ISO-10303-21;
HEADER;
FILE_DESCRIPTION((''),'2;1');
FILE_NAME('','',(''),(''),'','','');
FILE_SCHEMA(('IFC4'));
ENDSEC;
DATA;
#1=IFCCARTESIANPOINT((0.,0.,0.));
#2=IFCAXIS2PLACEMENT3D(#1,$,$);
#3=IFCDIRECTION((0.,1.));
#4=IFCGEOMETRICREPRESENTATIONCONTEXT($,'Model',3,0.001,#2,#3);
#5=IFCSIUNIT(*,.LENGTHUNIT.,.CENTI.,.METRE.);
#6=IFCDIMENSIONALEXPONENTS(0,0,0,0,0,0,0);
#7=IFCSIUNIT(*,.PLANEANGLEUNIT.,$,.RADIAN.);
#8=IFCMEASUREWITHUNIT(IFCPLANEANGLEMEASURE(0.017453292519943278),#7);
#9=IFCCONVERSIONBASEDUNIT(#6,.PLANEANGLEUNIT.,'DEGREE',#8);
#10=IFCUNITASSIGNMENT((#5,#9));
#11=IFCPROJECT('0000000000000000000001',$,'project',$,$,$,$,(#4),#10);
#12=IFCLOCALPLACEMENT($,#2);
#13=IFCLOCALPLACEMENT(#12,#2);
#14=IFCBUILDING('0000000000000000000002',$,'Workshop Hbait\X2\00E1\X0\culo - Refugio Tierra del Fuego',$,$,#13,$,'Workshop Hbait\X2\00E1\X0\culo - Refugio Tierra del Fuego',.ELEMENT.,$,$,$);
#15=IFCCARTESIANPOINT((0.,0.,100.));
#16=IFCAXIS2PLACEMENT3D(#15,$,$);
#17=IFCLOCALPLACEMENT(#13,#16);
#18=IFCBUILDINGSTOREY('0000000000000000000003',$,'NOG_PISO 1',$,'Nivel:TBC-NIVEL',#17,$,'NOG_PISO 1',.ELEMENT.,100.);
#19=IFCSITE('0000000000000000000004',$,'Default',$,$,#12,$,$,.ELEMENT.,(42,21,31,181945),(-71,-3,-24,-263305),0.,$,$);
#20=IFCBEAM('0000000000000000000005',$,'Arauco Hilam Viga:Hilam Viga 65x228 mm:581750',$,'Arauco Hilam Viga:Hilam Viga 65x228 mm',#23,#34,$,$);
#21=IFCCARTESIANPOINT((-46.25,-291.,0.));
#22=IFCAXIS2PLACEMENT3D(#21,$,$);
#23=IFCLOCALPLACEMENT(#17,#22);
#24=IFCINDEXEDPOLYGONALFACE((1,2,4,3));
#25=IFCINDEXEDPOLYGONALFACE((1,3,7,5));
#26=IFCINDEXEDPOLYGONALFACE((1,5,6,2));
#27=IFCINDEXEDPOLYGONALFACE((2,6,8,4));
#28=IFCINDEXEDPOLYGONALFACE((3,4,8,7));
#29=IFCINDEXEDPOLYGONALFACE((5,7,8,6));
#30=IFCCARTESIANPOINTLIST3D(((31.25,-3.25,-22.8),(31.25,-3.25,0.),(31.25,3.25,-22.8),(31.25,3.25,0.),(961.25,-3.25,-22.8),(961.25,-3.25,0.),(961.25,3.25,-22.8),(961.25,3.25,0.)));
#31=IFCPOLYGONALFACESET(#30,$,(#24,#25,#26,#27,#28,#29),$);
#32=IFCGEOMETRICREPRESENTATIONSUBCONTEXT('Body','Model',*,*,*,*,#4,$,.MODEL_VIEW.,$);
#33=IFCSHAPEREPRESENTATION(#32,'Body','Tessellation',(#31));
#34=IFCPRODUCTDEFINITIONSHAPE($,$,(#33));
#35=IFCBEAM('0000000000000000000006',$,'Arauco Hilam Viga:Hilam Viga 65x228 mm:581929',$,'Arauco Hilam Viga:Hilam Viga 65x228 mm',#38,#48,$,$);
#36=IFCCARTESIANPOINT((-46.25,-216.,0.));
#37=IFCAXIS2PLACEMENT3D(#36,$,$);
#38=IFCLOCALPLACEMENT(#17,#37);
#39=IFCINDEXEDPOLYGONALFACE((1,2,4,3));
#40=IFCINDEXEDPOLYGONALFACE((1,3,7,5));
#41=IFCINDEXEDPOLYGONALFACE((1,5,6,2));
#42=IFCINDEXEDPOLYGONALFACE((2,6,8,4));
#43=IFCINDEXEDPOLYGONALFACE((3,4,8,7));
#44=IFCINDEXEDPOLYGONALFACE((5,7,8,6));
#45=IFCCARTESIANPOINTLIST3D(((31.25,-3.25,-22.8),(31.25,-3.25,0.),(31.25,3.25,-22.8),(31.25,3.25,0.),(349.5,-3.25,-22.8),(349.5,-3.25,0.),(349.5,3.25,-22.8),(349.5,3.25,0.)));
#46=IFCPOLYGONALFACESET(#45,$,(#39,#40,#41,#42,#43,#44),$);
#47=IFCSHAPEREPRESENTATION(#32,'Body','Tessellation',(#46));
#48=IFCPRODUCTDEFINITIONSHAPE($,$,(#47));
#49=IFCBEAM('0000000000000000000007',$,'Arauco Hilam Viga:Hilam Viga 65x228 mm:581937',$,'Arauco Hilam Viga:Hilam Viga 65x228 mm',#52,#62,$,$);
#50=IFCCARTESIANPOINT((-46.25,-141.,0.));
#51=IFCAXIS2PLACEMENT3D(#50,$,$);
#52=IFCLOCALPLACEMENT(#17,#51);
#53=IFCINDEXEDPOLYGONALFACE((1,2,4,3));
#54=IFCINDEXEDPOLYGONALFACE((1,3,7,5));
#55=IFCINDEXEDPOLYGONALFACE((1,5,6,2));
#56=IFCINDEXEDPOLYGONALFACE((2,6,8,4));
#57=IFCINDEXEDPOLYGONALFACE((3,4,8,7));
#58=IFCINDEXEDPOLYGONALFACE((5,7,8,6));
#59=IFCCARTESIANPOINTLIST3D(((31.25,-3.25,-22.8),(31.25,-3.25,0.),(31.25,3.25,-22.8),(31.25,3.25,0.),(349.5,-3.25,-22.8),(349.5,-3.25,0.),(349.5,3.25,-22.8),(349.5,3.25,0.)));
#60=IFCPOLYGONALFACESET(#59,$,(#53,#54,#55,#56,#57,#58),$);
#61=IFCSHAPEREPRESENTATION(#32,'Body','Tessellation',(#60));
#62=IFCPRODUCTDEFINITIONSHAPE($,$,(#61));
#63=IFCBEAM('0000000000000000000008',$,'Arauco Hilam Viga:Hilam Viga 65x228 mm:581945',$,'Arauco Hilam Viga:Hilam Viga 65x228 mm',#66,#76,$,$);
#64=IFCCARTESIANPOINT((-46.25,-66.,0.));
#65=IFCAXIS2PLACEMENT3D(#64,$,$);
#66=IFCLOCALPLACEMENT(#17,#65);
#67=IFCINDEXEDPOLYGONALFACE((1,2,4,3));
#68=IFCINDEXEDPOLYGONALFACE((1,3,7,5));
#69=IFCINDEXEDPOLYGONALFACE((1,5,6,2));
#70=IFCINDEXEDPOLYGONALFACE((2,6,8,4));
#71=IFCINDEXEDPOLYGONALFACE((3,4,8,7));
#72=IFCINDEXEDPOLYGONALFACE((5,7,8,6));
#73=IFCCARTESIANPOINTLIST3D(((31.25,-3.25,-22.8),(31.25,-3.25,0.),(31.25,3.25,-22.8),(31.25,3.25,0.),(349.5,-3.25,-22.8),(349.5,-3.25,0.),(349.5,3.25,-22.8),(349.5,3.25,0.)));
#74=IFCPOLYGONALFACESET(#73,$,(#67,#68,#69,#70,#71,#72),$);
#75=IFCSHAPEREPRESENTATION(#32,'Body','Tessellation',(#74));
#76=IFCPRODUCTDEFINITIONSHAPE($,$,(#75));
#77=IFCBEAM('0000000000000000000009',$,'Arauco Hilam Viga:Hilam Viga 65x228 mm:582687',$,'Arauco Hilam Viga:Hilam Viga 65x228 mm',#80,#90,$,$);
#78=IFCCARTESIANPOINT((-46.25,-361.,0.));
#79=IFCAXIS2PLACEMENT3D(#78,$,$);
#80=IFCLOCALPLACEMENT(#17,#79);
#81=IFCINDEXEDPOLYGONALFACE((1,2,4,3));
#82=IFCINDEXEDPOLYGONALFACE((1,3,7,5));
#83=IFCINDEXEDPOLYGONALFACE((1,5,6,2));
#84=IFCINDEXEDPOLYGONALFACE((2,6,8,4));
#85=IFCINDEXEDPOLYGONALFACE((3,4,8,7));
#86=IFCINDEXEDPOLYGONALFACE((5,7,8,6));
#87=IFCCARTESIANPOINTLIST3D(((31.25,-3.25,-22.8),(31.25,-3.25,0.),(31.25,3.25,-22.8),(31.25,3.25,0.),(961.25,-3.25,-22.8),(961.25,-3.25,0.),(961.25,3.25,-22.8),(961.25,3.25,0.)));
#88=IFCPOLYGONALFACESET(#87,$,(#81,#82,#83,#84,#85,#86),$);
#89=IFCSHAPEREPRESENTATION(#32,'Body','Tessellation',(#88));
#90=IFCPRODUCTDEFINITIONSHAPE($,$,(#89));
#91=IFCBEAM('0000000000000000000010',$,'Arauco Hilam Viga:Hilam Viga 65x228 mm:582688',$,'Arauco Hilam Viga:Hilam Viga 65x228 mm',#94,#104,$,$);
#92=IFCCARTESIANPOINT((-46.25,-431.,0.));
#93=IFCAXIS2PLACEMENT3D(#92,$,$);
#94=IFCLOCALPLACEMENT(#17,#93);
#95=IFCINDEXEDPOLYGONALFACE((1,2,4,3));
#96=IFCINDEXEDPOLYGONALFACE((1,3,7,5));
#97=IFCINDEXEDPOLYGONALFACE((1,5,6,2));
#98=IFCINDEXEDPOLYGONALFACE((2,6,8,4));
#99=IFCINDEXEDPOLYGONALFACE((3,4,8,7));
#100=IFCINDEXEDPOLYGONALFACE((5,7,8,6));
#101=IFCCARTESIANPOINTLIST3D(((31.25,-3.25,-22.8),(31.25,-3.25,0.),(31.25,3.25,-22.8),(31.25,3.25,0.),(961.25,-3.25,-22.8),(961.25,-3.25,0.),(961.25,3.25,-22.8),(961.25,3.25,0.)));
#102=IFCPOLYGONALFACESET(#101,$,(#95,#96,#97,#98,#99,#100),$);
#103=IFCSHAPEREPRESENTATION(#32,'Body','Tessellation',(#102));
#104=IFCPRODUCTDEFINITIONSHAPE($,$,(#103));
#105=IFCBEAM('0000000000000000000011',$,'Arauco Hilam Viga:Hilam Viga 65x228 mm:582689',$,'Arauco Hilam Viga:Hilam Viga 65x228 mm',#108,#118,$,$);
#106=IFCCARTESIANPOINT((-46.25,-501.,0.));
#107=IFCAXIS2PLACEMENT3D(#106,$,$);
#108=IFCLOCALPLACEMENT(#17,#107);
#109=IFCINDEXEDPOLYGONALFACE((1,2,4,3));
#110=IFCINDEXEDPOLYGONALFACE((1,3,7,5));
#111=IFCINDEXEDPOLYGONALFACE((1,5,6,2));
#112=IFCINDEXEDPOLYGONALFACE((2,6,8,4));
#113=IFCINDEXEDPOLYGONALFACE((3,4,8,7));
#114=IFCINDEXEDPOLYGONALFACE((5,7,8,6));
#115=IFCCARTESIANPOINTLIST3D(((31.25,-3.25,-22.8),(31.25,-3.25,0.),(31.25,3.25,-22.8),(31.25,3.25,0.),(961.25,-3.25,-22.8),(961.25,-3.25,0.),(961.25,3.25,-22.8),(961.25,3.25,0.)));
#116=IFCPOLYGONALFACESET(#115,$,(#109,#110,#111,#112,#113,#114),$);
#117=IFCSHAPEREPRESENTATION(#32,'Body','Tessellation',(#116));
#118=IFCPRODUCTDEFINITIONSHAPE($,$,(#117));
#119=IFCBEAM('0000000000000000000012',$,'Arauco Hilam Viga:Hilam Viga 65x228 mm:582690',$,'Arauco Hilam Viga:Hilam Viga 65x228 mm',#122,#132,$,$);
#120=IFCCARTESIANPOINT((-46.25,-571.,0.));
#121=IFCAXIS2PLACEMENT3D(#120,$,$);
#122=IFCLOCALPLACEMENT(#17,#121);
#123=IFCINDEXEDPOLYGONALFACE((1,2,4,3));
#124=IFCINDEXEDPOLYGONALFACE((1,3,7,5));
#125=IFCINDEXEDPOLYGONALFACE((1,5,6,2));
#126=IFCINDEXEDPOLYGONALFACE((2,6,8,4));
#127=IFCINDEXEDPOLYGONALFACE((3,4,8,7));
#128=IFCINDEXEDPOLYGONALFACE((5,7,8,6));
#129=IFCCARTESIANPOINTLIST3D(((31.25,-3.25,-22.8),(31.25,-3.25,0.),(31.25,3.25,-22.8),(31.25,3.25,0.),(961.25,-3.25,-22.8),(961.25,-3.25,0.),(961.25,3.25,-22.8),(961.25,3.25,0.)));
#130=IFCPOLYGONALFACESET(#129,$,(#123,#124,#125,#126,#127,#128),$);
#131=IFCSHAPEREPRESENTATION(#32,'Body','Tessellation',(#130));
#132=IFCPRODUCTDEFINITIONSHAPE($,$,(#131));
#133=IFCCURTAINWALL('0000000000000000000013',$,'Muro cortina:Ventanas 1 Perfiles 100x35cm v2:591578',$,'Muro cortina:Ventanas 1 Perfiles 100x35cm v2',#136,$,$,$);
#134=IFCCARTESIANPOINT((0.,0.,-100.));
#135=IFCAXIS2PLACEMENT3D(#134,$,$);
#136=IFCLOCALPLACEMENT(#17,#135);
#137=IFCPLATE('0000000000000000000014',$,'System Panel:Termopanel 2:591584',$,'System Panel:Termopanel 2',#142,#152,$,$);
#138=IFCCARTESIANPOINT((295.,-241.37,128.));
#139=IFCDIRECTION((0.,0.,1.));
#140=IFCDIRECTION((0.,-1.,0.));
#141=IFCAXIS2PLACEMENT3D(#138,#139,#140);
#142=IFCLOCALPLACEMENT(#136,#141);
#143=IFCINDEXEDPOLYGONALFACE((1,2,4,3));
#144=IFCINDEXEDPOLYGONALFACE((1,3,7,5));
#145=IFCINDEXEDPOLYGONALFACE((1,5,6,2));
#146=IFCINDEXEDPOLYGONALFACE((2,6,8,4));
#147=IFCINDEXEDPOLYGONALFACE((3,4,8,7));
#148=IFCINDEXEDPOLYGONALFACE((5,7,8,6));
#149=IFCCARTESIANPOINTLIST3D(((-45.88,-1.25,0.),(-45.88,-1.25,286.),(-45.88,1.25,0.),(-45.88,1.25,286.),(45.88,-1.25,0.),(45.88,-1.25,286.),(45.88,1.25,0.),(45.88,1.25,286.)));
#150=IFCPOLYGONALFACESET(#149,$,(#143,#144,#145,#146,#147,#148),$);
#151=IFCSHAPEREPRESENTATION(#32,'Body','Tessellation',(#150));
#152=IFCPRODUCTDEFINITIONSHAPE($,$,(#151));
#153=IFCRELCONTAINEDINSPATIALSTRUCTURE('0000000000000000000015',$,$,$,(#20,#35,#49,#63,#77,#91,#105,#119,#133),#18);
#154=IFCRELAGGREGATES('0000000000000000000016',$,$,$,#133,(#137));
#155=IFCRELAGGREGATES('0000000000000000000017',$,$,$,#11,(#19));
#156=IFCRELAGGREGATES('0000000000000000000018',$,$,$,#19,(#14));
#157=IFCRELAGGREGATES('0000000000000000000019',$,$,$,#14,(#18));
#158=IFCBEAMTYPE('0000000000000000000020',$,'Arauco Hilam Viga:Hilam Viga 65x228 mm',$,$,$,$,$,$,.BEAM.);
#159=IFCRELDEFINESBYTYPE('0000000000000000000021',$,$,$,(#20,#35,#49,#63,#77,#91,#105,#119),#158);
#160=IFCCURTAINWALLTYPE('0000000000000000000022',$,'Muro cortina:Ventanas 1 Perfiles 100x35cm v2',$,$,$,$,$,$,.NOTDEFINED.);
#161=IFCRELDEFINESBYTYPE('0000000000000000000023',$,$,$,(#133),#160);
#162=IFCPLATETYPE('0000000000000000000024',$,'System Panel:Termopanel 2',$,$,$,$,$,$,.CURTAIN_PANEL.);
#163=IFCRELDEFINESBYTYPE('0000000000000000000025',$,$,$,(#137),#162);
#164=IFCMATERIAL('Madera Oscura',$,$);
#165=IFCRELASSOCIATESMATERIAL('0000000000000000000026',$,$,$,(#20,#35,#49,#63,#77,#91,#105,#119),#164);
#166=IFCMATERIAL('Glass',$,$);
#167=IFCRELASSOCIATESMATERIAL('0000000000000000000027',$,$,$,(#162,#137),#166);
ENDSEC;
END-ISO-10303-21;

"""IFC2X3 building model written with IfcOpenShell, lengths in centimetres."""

from ifc_helpers import new_model, entity, si_unit, converted_unit, direction, frame, frame_2d, origin, origin_2d_with_axis, place, context, subcontext, project, spatial, rectangle, extrude, source, transform, mapped, material, type_object, type_shapes, element, aggregate, save


model = new_model("IFC2X3")

# Units and contexts
model_context = context("Model", 3, precision=0.001, world=origin(), true_north=direction((0.0, 1.0)))
body_context = subcontext(model_context, "Body", "Model", "MODEL_VIEW")
ifc_project = project(units=[si_unit("LENGTHUNIT", "METRE", prefix="CENTI"), converted_unit("PLANEANGLEUNIT", "DEGREE", entity("IfcPlaneAngleMeasure", 0.017453292519943278), si_unit("PLANEANGLEUNIT", "RADIAN"), dimensions=[0, 0, 0, 0, 0, 0, 0])], contexts=[model_context])

# Site, building, storey
site_placement = place(None, origin())
site = spatial("IfcSite", under=ifc_project, at=site_placement, Name="Default", CompositionType="ELEMENT", RefLatitude=(42, 21, 31, 181945), RefLongitude=(-71, -3, -24, -263305), RefElevation=0.0)
building_placement = place(site_placement, origin())
building = spatial("IfcBuilding", under=site, at=building_placement, Name="Workshop Hbaitáculo - Refugio Tierra del Fuego", LongName="Workshop Hbaitáculo - Refugio Tierra del Fuego", CompositionType="ELEMENT")
storey_placement = place(building_placement, frame((0.0, 0.0, 100.0)))
storey = spatial("IfcBuildingStorey", under=building, at=storey_placement, Name="NOG_PISO 1", ObjectType="Nivel:TBC-NIVEL", LongName="NOG_PISO 1", CompositionType="ELEMENT", Elevation=100.0)

# Beams
ifc_material_1 = material(Name="Madera Oscura")
beam_type = type_object("IfcBeamType", Name="Arauco Hilam Viga:Hilam Viga 65x228 mm", PredefinedType="BEAM")
beam_1_placement = place(storey_placement, frame((-46.25, -291.0, 0.0)))
element("IfcBeam", 1, at=beam_1_placement, inside=storey, type_object=beam_type, material=ifc_material_1, Name="Arauco Hilam Viga:Hilam Viga 65x228 mm:581750", ObjectType="Arauco Hilam Viga:Hilam Viga 65x228 mm", context=body_context, shape_type="SweptSolid", body=[
    extrude(rectangle(XDim=22.8, YDim=6.5, at=origin_2d_with_axis()), frame((31.25, 0.0, -11.4), z_axis=(1.0, 0.0, 0.0), x_axis=(0.0, 0.0, -1.0)), (0.0, 0.0, 1.0), 930.0),
])
beam_2_placement = place(storey_placement, frame((-46.25, -216.0, 0.0)))
element("IfcBeam", 2, at=beam_2_placement, inside=storey, type_object=beam_type, material=ifc_material_1, Name="Arauco Hilam Viga:Hilam Viga 65x228 mm:581929", ObjectType="Arauco Hilam Viga:Hilam Viga 65x228 mm", context=body_context, shape_type="SweptSolid", body=[
    extrude(rectangle(XDim=22.8, YDim=6.5, at=frame_2d((0.0, 0.0), x_axis=(1.0, 0.0))), frame((31.25, 0.0, -11.4), z_axis=(1.0, 0.0, 0.0), x_axis=(0.0, 0.0, -1.0)), (0.0, 0.0, 1.0), 318.25),
])
beam_3_placement = place(storey_placement, frame((-46.25, -141.0, 0.0)))
element("IfcBeam", 3, at=beam_3_placement, inside=storey, type_object=beam_type, material=ifc_material_1, Name="Arauco Hilam Viga:Hilam Viga 65x228 mm:581937", ObjectType="Arauco Hilam Viga:Hilam Viga 65x228 mm", context=body_context, shape_type="SweptSolid", body=[
    extrude(rectangle(XDim=22.8, YDim=6.5, at=origin_2d_with_axis()), frame((31.25, 0.0, -11.4), z_axis=(1.0, 0.0, 0.0), x_axis=(0.0, 0.0, -1.0)), (0.0, 0.0, 1.0), 318.25),
])
beam_4_placement = place(storey_placement, frame((-46.25, -66.0, 0.0)))
element("IfcBeam", 4, at=beam_4_placement, inside=storey, type_object=beam_type, material=ifc_material_1, Name="Arauco Hilam Viga:Hilam Viga 65x228 mm:581945", ObjectType="Arauco Hilam Viga:Hilam Viga 65x228 mm", context=body_context, shape_type="SweptSolid", body=[
    extrude(rectangle(XDim=22.8, YDim=6.5, at=frame_2d((0.0, 0.0), x_axis=(1.0, 0.0))), frame((31.25, 0.0, -11.4), z_axis=(1.0, 0.0, 0.0), x_axis=(0.0, 0.0, -1.0)), (0.0, 0.0, 1.0), 318.25),
])
beam_5_placement = place(storey_placement, frame((-46.25, -361.0, 0.0)))
element("IfcBeam", 5, at=beam_5_placement, inside=storey, type_object=beam_type, material=ifc_material_1, Name="Arauco Hilam Viga:Hilam Viga 65x228 mm:582687", ObjectType="Arauco Hilam Viga:Hilam Viga 65x228 mm", context=body_context, shape_type="SweptSolid", body=[
    extrude(rectangle(XDim=22.8, YDim=6.5, at=frame_2d((0.0, 0.0), x_axis=(1.0, 0.0))), frame((31.25, 0.0, -11.4), z_axis=(1.0, 0.0, 0.0), x_axis=(0.0, 0.0, -1.0)), (0.0, 0.0, 1.0), 930.0),
])
beam_6_placement = place(storey_placement, frame((-46.25, -431.0, 0.0)))
element("IfcBeam", 6, at=beam_6_placement, inside=storey, type_object=beam_type, material=ifc_material_1, Name="Arauco Hilam Viga:Hilam Viga 65x228 mm:582688", ObjectType="Arauco Hilam Viga:Hilam Viga 65x228 mm", context=body_context, shape_type="SweptSolid", body=[
    extrude(rectangle(XDim=22.8, YDim=6.5, at=frame_2d((0.0, 0.0), x_axis=(1.0, 0.0))), frame((31.25, 0.0, -11.4), z_axis=(1.0, 0.0, 0.0), x_axis=(0.0, 0.0, -1.0)), (0.0, 0.0, 1.0), 930.0),
])
for number, where, name in (
    (7, (-46.25, -501.0, 0.0), "Arauco Hilam Viga:Hilam Viga 65x228 mm:582689"),
    (8, (-46.25, -571.0, 0.0), "Arauco Hilam Viga:Hilam Viga 65x228 mm:582690"),
):
    element("IfcBeam", number, at=place(storey_placement, frame(where)), inside=storey, type_object=beam_type, material=ifc_material_1, Name=name, ObjectType="Arauco Hilam Viga:Hilam Viga 65x228 mm", context=body_context, shape_type="SweptSolid", body=[
        extrude(rectangle(XDim=22.8, YDim=6.5, at=origin_2d_with_axis()), frame((31.25, 0.0, -11.4), z_axis=(1.0, 0.0, 0.0), x_axis=(0.0, 0.0, -1.0)), (0.0, 0.0, 1.0), 930.0),
    ])

# Curtain wall, plate
curtain_wall_type = type_object("IfcCurtainWallType", Name="Muro cortina:Ventanas 1 Perfiles 100x35cm v2", PredefinedType="NOTDEFINED")
curtain_wall_placement = place(storey_placement, frame((0.0, 0.0, -100.0)))
curtain_wall = element("IfcCurtainWall", 9, at=curtain_wall_placement, inside=storey, type_object=curtain_wall_type, Name="Muro cortina:Ventanas 1 Perfiles 100x35cm v2:591578", ObjectType="Muro cortina:Ventanas 1 Perfiles 100x35cm v2")
ifc_material_2 = material(Name="Glass")
plate_type = type_object("IfcPlateType", Name="System Panel:Termopanel 2", PredefinedType="CURTAIN_PANEL", material=ifc_material_2)
shared_shape_1 = source(origin(), body_context, "Body", "SweptSolid", [
    extrude(rectangle(XDim=2.5, YDim=91.75, at=frame_2d((0.0, 0.0), x_axis=(1.0, 0.0))), frame((0.0, 0.0, 0.0), z_axis=(0.0, 0.0, 1.0), x_axis=(0.0, 1.0, 0.0)), (0.0, 0.0, 1.0), 286.0),
])
type_shapes(plate_type, [shared_shape_1])
plate_placement = place(curtain_wall_placement, frame((295.0, -241.37, 128.0), z_axis=(0.0, 0.0, 1.0), x_axis=(0.0, -1.0, 0.0)))
plate = element("IfcPlate", 10, at=plate_placement, type_object=plate_type, material=ifc_material_2, Name="System Panel:Termopanel 2:591584", ObjectType="System Panel:Termopanel 2", context=body_context, shape_type="MappedRepresentation", body=[
    mapped(shared_shape_1, transform((0.0, 0.0, 0.0), scale=1.0)),
])
aggregate(curtain_wall, [plate])

save(model, "model.ifc")
